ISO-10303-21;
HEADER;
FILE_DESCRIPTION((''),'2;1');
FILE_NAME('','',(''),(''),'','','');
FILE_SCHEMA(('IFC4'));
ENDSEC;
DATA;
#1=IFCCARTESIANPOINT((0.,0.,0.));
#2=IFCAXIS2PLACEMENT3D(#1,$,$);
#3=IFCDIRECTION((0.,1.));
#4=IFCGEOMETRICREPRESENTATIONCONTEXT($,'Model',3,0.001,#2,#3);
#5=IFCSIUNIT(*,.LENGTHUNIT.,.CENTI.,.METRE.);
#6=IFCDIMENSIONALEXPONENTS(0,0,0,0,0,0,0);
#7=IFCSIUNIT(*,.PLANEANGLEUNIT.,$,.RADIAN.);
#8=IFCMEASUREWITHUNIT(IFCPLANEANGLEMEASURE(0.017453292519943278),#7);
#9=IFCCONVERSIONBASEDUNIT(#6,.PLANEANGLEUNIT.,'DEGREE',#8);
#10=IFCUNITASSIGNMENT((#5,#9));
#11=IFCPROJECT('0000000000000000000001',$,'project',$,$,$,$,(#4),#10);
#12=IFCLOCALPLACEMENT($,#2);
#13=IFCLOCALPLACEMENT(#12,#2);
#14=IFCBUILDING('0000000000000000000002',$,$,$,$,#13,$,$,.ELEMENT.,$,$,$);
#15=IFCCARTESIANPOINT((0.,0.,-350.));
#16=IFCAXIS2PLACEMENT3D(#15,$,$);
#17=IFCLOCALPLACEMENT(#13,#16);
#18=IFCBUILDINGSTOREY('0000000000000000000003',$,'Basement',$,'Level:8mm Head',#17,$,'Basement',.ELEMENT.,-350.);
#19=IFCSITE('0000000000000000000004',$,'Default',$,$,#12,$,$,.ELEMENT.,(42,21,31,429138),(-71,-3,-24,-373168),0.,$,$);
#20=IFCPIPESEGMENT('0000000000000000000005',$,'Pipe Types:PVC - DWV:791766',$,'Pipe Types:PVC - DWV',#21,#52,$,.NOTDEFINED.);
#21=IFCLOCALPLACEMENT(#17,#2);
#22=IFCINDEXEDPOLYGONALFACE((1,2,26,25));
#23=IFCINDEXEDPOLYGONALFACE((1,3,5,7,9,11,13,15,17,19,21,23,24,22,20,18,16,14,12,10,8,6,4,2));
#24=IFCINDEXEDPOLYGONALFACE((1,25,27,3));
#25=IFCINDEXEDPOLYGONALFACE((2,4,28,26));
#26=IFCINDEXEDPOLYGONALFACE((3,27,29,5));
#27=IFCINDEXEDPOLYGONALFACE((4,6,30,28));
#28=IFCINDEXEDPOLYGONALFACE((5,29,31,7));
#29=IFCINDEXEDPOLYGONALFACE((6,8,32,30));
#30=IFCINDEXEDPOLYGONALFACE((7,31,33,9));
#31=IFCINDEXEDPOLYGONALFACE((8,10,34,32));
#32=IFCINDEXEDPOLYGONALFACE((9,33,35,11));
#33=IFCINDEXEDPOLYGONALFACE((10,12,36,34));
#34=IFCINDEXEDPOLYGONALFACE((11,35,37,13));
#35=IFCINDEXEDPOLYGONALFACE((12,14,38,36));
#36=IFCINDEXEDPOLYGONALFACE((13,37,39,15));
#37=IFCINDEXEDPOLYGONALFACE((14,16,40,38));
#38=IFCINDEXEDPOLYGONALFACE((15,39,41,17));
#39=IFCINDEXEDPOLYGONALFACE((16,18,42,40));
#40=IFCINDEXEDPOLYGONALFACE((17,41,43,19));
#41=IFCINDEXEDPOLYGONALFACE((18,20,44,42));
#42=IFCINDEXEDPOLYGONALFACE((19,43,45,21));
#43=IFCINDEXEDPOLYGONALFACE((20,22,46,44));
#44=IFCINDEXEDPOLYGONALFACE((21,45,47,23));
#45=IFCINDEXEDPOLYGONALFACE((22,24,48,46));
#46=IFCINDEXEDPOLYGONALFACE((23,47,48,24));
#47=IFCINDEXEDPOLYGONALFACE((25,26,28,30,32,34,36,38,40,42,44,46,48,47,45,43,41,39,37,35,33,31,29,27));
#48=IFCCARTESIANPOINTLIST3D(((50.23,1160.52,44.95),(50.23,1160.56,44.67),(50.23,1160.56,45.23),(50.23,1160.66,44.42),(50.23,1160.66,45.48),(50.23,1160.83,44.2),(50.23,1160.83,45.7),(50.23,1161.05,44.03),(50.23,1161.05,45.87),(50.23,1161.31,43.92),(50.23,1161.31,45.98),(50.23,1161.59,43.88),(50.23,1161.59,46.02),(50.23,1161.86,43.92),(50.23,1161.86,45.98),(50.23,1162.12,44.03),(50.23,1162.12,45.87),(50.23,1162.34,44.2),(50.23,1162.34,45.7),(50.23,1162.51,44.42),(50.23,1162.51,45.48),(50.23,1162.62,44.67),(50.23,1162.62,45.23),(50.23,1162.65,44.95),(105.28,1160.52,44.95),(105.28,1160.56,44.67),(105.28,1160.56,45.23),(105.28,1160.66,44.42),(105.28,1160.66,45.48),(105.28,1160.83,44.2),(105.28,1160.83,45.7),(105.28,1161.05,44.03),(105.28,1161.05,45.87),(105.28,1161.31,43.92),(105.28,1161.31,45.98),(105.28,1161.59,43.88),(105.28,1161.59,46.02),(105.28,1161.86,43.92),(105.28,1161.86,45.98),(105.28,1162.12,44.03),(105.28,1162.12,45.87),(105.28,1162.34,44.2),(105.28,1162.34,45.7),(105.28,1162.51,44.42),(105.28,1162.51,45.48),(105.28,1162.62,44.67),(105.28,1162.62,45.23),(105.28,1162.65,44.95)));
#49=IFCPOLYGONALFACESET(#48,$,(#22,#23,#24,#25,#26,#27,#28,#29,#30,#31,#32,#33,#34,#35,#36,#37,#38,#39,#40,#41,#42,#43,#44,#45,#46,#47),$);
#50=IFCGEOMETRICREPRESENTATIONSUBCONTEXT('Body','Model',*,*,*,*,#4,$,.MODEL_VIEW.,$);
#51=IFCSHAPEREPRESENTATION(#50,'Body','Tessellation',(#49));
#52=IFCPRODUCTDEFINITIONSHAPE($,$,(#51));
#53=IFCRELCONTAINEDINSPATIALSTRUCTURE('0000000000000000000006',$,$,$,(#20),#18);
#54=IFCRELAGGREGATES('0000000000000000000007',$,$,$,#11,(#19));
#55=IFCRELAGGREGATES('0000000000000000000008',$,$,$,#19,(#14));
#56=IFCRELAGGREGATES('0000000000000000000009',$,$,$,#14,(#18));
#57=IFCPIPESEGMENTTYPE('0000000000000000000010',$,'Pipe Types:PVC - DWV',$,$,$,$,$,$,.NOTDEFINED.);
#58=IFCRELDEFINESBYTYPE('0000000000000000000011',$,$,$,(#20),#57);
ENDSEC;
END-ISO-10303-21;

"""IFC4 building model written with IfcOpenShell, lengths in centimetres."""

from ifc_helpers import new_model, entity, si_unit, converted_unit, direction, frame, origin, place, context, subcontext, project, spatial, arc, indexed_curve, outline, extrude, type_object, element, save


model = new_model("IFC4")

# Units and contexts
model_context = context("Model", 3, precision=0.001, world=origin(), true_north=direction((0.0, 1.0)))
body_context = subcontext(model_context, "Body", "Model", "MODEL_VIEW")
ifc_project = project(units=[si_unit("LENGTHUNIT", "METRE", prefix="CENTI"), converted_unit("PLANEANGLEUNIT", "DEGREE", entity("IfcPlaneAngleMeasure", 0.017453292519943278), si_unit("PLANEANGLEUNIT", "RADIAN"), dimensions=[0, 0, 0, 0, 0, 0, 0])], contexts=[model_context])

# Site, building, storey
site_placement = place(None, origin())
site = spatial("IfcSite", under=ifc_project, at=site_placement, Name="Default", CompositionType="ELEMENT", RefLatitude=(42, 21, 31, 429138), RefLongitude=(-71, -3, -24, -373168), RefElevation=0.0)
building_placement = place(site_placement, origin())
building = spatial("IfcBuilding", under=site, at=building_placement, CompositionType="ELEMENT")
storey_placement = place(building_placement, frame((0.0, 0.0, -350.0)))
storey = spatial("IfcBuildingStorey", under=building, at=storey_placement, Name="Basement", ObjectType="Level:8mm Head", LongName="Basement", CompositionType="ELEMENT", Elevation=-350.0)

# Pipe segment
pipe_segment_type = type_object("IfcPipeSegmentType", Name="Pipe Types:PVC - DWV", PredefinedType="NOTDEFINED")
pipe_segment_1_placement = place(storey_placement, origin())
element("IfcPipeSegment", 1, at=pipe_segment_1_placement, inside=storey, type_object=pipe_segment_type, Name="Pipe Types:PVC - DWV:791766", ObjectType="Pipe Types:PVC - DWV", PredefinedType="NOTDEFINED", context=body_context, shape_type="SweptSolid", body=[
    extrude(outline(indexed_curve([(1.07, 0.0), (0.75, 0.75), (0.0, 1.07), (-0.75, 0.75), (-1.07, 0.0), (-0.75, -0.75), (0.0, -1.07), (0.75, -0.75)], segments=[arc(1, 2, 3), arc(3, 4, 5), arc(5, 6, 7), arc(7, 8, 1)], self_intersect=False)), frame((50.23, 1161.59, 44.95), z_axis=(1.0, 0.0, 0.0), x_axis=(0.0, 1.0, 0.0)), (0.0, 0.0, 1.0), 55.04),
])

save(model, "model.ifc")
